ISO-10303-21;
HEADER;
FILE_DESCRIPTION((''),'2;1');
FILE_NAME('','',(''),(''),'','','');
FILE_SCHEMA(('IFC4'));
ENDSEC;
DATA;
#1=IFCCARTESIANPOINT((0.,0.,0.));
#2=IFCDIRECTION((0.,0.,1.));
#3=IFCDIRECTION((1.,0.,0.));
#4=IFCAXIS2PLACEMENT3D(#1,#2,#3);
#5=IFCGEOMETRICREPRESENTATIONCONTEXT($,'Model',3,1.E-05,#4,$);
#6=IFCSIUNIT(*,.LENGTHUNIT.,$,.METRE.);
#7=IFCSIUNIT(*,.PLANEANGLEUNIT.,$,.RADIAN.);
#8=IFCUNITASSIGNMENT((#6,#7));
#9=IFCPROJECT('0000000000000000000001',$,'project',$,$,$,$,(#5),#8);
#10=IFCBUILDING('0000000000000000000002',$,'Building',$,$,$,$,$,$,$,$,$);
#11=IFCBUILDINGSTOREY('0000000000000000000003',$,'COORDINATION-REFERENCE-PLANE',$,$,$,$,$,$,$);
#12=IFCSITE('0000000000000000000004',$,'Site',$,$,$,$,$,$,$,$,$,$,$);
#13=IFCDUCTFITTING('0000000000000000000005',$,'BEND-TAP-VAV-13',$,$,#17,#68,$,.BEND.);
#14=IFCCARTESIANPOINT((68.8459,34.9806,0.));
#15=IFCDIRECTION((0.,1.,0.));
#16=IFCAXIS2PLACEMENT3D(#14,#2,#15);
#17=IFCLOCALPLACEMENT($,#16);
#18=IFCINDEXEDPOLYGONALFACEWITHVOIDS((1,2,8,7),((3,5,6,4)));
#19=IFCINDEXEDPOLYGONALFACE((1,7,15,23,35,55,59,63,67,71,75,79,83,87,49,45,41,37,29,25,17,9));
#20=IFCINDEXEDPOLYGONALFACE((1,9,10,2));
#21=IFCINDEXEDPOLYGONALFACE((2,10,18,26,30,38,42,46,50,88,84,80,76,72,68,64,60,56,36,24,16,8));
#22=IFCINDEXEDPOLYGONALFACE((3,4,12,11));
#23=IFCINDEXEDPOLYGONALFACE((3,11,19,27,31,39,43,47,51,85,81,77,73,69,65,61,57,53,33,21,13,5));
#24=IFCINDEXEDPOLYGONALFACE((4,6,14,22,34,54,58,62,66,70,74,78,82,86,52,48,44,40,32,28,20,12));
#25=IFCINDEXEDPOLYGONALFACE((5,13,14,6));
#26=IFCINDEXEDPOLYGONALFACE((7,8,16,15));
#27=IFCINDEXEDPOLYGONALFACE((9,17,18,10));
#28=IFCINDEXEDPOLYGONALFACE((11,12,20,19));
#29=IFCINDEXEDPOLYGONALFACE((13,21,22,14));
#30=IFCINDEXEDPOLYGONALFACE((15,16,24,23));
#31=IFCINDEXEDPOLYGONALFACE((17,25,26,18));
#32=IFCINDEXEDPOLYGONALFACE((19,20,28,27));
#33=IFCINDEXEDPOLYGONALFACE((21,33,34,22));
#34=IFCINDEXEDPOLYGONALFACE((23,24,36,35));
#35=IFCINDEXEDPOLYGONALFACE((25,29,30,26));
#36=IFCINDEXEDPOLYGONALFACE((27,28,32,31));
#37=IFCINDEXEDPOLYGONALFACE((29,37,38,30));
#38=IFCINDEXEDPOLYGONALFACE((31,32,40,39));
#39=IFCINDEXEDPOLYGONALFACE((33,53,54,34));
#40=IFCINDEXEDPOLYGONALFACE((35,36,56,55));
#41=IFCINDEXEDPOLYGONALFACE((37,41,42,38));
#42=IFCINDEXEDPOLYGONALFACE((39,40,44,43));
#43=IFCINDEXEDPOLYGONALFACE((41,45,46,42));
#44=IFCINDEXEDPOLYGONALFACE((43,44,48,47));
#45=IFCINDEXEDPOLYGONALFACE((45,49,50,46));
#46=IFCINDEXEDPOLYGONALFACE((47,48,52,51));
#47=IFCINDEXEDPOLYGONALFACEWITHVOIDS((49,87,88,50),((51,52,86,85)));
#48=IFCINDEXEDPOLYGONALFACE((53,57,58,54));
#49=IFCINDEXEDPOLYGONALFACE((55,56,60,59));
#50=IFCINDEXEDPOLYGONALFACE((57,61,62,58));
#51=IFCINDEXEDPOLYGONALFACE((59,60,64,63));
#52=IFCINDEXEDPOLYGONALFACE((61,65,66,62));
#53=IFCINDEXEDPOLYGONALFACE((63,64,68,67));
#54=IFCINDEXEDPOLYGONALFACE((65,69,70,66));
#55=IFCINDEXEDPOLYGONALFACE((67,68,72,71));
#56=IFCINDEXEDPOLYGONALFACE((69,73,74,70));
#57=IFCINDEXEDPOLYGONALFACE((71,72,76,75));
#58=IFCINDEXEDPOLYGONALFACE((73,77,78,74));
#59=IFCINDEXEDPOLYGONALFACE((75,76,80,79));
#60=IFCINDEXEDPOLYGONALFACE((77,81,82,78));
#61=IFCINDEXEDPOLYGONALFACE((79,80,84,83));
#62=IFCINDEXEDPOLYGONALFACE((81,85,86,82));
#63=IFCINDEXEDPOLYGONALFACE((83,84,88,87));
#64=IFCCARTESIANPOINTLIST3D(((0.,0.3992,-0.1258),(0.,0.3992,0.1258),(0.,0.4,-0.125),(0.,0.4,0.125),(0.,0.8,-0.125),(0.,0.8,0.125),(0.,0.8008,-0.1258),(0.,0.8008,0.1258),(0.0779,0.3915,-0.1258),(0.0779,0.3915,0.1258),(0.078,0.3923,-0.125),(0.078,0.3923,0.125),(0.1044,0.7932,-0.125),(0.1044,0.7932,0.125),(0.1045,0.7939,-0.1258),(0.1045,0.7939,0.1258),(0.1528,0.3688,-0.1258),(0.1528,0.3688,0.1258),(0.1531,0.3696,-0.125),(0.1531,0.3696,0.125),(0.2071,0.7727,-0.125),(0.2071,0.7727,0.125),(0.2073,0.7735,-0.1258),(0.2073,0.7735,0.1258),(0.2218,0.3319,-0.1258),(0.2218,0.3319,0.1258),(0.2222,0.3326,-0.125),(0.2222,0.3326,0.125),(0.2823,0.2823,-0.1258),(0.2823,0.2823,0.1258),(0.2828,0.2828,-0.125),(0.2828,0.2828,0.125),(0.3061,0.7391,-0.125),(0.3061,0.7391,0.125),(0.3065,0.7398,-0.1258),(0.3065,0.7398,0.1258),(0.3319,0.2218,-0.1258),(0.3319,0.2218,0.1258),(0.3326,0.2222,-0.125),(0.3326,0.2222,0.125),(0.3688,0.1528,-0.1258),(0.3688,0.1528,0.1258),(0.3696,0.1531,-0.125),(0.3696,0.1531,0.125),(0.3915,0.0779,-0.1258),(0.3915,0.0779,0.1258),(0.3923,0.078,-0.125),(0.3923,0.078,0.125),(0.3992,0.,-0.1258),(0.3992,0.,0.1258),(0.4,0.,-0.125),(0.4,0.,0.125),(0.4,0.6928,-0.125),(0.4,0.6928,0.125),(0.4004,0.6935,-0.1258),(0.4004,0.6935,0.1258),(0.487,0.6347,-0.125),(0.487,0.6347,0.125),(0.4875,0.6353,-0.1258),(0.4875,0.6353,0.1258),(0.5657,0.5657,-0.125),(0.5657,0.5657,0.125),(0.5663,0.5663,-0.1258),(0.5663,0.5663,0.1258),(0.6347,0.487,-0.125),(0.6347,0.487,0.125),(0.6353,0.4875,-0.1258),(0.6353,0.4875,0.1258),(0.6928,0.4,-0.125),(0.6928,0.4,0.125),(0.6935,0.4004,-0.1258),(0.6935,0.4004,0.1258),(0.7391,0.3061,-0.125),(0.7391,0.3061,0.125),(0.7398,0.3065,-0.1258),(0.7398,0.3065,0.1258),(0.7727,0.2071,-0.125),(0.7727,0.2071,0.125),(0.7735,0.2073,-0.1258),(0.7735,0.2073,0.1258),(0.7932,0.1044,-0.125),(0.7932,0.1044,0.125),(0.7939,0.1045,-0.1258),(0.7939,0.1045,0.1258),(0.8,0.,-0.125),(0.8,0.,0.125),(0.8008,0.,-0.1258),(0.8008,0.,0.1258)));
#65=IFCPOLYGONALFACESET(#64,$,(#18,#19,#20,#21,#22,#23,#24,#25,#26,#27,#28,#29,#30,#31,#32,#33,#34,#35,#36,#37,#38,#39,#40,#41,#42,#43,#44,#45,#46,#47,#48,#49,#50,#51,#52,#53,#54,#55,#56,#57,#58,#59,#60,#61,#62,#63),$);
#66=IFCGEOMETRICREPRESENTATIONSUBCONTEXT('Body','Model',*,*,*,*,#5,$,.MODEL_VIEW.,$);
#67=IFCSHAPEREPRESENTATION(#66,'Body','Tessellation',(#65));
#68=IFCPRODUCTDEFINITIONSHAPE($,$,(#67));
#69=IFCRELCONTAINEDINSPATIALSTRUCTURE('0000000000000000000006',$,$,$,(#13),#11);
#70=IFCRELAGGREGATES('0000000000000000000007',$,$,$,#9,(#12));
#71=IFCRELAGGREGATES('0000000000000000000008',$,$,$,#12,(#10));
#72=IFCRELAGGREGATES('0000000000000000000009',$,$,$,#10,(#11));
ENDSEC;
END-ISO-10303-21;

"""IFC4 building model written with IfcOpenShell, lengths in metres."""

from ifc_helpers import new_model, entity, si_unit, frame, origin_with_axes, place, context, subcontext, project, spatial, element, save


model = new_model("IFC4")

# Units and contexts
model_context = context("Model", 3, precision=1e-05, world=origin_with_axes())
body_context_1 = subcontext(model_context, "Body", "Model", "MODEL_VIEW")
ifc_project = project(units=[si_unit("LENGTHUNIT", "METRE"), si_unit("PLANEANGLEUNIT", "RADIAN")], contexts=[model_context])

# Site, building, storey
site = spatial("IfcSite", under=ifc_project, Name="Site")
building = spatial("IfcBuilding", under=site, Name="Building")
storey = spatial("IfcBuildingStorey", under=building, Name="COORDINATION-REFERENCE-PLANE")

# Duct fitting
duct_fitting_1_placement = place(None, frame((68.8459, 34.9806, 0.0), z_axis=(0.0, 0.0, 1.0), x_axis=(0.0, 1.0, 0.0)))
cartesian_point = entity("IfcCartesianPoint", [0.0, 0.0, 0.0])
element("IfcDuctFitting", 1, at=duct_fitting_1_placement, inside=storey, Name="BEND-TAP-VAV-13", PredefinedType="BEND", context=body_context_1, shape_type="SweptSolid", body=[
    entity("IfcRevolvedAreaSolid", entity("IfcRectangleHollowProfileDef", "AREA", None, entity("IfcAxis2Placement2D", entity("IfcCartesianPoint", [0.6, 0.0])), 0.4016, 0.2516, 0.0008), entity("IfcAxis2Placement3D", cartesian_point, entity("IfcDirection", [0.0, -1.0, 0.0]), entity("IfcDirection", [1.0, 0.0, 0.0])), entity("IfcAxis1Placement", cartesian_point, entity("IfcDirection", [0.0, 1.0, 0.0])), 1.570796),
])

save(model, "model.ifc")
